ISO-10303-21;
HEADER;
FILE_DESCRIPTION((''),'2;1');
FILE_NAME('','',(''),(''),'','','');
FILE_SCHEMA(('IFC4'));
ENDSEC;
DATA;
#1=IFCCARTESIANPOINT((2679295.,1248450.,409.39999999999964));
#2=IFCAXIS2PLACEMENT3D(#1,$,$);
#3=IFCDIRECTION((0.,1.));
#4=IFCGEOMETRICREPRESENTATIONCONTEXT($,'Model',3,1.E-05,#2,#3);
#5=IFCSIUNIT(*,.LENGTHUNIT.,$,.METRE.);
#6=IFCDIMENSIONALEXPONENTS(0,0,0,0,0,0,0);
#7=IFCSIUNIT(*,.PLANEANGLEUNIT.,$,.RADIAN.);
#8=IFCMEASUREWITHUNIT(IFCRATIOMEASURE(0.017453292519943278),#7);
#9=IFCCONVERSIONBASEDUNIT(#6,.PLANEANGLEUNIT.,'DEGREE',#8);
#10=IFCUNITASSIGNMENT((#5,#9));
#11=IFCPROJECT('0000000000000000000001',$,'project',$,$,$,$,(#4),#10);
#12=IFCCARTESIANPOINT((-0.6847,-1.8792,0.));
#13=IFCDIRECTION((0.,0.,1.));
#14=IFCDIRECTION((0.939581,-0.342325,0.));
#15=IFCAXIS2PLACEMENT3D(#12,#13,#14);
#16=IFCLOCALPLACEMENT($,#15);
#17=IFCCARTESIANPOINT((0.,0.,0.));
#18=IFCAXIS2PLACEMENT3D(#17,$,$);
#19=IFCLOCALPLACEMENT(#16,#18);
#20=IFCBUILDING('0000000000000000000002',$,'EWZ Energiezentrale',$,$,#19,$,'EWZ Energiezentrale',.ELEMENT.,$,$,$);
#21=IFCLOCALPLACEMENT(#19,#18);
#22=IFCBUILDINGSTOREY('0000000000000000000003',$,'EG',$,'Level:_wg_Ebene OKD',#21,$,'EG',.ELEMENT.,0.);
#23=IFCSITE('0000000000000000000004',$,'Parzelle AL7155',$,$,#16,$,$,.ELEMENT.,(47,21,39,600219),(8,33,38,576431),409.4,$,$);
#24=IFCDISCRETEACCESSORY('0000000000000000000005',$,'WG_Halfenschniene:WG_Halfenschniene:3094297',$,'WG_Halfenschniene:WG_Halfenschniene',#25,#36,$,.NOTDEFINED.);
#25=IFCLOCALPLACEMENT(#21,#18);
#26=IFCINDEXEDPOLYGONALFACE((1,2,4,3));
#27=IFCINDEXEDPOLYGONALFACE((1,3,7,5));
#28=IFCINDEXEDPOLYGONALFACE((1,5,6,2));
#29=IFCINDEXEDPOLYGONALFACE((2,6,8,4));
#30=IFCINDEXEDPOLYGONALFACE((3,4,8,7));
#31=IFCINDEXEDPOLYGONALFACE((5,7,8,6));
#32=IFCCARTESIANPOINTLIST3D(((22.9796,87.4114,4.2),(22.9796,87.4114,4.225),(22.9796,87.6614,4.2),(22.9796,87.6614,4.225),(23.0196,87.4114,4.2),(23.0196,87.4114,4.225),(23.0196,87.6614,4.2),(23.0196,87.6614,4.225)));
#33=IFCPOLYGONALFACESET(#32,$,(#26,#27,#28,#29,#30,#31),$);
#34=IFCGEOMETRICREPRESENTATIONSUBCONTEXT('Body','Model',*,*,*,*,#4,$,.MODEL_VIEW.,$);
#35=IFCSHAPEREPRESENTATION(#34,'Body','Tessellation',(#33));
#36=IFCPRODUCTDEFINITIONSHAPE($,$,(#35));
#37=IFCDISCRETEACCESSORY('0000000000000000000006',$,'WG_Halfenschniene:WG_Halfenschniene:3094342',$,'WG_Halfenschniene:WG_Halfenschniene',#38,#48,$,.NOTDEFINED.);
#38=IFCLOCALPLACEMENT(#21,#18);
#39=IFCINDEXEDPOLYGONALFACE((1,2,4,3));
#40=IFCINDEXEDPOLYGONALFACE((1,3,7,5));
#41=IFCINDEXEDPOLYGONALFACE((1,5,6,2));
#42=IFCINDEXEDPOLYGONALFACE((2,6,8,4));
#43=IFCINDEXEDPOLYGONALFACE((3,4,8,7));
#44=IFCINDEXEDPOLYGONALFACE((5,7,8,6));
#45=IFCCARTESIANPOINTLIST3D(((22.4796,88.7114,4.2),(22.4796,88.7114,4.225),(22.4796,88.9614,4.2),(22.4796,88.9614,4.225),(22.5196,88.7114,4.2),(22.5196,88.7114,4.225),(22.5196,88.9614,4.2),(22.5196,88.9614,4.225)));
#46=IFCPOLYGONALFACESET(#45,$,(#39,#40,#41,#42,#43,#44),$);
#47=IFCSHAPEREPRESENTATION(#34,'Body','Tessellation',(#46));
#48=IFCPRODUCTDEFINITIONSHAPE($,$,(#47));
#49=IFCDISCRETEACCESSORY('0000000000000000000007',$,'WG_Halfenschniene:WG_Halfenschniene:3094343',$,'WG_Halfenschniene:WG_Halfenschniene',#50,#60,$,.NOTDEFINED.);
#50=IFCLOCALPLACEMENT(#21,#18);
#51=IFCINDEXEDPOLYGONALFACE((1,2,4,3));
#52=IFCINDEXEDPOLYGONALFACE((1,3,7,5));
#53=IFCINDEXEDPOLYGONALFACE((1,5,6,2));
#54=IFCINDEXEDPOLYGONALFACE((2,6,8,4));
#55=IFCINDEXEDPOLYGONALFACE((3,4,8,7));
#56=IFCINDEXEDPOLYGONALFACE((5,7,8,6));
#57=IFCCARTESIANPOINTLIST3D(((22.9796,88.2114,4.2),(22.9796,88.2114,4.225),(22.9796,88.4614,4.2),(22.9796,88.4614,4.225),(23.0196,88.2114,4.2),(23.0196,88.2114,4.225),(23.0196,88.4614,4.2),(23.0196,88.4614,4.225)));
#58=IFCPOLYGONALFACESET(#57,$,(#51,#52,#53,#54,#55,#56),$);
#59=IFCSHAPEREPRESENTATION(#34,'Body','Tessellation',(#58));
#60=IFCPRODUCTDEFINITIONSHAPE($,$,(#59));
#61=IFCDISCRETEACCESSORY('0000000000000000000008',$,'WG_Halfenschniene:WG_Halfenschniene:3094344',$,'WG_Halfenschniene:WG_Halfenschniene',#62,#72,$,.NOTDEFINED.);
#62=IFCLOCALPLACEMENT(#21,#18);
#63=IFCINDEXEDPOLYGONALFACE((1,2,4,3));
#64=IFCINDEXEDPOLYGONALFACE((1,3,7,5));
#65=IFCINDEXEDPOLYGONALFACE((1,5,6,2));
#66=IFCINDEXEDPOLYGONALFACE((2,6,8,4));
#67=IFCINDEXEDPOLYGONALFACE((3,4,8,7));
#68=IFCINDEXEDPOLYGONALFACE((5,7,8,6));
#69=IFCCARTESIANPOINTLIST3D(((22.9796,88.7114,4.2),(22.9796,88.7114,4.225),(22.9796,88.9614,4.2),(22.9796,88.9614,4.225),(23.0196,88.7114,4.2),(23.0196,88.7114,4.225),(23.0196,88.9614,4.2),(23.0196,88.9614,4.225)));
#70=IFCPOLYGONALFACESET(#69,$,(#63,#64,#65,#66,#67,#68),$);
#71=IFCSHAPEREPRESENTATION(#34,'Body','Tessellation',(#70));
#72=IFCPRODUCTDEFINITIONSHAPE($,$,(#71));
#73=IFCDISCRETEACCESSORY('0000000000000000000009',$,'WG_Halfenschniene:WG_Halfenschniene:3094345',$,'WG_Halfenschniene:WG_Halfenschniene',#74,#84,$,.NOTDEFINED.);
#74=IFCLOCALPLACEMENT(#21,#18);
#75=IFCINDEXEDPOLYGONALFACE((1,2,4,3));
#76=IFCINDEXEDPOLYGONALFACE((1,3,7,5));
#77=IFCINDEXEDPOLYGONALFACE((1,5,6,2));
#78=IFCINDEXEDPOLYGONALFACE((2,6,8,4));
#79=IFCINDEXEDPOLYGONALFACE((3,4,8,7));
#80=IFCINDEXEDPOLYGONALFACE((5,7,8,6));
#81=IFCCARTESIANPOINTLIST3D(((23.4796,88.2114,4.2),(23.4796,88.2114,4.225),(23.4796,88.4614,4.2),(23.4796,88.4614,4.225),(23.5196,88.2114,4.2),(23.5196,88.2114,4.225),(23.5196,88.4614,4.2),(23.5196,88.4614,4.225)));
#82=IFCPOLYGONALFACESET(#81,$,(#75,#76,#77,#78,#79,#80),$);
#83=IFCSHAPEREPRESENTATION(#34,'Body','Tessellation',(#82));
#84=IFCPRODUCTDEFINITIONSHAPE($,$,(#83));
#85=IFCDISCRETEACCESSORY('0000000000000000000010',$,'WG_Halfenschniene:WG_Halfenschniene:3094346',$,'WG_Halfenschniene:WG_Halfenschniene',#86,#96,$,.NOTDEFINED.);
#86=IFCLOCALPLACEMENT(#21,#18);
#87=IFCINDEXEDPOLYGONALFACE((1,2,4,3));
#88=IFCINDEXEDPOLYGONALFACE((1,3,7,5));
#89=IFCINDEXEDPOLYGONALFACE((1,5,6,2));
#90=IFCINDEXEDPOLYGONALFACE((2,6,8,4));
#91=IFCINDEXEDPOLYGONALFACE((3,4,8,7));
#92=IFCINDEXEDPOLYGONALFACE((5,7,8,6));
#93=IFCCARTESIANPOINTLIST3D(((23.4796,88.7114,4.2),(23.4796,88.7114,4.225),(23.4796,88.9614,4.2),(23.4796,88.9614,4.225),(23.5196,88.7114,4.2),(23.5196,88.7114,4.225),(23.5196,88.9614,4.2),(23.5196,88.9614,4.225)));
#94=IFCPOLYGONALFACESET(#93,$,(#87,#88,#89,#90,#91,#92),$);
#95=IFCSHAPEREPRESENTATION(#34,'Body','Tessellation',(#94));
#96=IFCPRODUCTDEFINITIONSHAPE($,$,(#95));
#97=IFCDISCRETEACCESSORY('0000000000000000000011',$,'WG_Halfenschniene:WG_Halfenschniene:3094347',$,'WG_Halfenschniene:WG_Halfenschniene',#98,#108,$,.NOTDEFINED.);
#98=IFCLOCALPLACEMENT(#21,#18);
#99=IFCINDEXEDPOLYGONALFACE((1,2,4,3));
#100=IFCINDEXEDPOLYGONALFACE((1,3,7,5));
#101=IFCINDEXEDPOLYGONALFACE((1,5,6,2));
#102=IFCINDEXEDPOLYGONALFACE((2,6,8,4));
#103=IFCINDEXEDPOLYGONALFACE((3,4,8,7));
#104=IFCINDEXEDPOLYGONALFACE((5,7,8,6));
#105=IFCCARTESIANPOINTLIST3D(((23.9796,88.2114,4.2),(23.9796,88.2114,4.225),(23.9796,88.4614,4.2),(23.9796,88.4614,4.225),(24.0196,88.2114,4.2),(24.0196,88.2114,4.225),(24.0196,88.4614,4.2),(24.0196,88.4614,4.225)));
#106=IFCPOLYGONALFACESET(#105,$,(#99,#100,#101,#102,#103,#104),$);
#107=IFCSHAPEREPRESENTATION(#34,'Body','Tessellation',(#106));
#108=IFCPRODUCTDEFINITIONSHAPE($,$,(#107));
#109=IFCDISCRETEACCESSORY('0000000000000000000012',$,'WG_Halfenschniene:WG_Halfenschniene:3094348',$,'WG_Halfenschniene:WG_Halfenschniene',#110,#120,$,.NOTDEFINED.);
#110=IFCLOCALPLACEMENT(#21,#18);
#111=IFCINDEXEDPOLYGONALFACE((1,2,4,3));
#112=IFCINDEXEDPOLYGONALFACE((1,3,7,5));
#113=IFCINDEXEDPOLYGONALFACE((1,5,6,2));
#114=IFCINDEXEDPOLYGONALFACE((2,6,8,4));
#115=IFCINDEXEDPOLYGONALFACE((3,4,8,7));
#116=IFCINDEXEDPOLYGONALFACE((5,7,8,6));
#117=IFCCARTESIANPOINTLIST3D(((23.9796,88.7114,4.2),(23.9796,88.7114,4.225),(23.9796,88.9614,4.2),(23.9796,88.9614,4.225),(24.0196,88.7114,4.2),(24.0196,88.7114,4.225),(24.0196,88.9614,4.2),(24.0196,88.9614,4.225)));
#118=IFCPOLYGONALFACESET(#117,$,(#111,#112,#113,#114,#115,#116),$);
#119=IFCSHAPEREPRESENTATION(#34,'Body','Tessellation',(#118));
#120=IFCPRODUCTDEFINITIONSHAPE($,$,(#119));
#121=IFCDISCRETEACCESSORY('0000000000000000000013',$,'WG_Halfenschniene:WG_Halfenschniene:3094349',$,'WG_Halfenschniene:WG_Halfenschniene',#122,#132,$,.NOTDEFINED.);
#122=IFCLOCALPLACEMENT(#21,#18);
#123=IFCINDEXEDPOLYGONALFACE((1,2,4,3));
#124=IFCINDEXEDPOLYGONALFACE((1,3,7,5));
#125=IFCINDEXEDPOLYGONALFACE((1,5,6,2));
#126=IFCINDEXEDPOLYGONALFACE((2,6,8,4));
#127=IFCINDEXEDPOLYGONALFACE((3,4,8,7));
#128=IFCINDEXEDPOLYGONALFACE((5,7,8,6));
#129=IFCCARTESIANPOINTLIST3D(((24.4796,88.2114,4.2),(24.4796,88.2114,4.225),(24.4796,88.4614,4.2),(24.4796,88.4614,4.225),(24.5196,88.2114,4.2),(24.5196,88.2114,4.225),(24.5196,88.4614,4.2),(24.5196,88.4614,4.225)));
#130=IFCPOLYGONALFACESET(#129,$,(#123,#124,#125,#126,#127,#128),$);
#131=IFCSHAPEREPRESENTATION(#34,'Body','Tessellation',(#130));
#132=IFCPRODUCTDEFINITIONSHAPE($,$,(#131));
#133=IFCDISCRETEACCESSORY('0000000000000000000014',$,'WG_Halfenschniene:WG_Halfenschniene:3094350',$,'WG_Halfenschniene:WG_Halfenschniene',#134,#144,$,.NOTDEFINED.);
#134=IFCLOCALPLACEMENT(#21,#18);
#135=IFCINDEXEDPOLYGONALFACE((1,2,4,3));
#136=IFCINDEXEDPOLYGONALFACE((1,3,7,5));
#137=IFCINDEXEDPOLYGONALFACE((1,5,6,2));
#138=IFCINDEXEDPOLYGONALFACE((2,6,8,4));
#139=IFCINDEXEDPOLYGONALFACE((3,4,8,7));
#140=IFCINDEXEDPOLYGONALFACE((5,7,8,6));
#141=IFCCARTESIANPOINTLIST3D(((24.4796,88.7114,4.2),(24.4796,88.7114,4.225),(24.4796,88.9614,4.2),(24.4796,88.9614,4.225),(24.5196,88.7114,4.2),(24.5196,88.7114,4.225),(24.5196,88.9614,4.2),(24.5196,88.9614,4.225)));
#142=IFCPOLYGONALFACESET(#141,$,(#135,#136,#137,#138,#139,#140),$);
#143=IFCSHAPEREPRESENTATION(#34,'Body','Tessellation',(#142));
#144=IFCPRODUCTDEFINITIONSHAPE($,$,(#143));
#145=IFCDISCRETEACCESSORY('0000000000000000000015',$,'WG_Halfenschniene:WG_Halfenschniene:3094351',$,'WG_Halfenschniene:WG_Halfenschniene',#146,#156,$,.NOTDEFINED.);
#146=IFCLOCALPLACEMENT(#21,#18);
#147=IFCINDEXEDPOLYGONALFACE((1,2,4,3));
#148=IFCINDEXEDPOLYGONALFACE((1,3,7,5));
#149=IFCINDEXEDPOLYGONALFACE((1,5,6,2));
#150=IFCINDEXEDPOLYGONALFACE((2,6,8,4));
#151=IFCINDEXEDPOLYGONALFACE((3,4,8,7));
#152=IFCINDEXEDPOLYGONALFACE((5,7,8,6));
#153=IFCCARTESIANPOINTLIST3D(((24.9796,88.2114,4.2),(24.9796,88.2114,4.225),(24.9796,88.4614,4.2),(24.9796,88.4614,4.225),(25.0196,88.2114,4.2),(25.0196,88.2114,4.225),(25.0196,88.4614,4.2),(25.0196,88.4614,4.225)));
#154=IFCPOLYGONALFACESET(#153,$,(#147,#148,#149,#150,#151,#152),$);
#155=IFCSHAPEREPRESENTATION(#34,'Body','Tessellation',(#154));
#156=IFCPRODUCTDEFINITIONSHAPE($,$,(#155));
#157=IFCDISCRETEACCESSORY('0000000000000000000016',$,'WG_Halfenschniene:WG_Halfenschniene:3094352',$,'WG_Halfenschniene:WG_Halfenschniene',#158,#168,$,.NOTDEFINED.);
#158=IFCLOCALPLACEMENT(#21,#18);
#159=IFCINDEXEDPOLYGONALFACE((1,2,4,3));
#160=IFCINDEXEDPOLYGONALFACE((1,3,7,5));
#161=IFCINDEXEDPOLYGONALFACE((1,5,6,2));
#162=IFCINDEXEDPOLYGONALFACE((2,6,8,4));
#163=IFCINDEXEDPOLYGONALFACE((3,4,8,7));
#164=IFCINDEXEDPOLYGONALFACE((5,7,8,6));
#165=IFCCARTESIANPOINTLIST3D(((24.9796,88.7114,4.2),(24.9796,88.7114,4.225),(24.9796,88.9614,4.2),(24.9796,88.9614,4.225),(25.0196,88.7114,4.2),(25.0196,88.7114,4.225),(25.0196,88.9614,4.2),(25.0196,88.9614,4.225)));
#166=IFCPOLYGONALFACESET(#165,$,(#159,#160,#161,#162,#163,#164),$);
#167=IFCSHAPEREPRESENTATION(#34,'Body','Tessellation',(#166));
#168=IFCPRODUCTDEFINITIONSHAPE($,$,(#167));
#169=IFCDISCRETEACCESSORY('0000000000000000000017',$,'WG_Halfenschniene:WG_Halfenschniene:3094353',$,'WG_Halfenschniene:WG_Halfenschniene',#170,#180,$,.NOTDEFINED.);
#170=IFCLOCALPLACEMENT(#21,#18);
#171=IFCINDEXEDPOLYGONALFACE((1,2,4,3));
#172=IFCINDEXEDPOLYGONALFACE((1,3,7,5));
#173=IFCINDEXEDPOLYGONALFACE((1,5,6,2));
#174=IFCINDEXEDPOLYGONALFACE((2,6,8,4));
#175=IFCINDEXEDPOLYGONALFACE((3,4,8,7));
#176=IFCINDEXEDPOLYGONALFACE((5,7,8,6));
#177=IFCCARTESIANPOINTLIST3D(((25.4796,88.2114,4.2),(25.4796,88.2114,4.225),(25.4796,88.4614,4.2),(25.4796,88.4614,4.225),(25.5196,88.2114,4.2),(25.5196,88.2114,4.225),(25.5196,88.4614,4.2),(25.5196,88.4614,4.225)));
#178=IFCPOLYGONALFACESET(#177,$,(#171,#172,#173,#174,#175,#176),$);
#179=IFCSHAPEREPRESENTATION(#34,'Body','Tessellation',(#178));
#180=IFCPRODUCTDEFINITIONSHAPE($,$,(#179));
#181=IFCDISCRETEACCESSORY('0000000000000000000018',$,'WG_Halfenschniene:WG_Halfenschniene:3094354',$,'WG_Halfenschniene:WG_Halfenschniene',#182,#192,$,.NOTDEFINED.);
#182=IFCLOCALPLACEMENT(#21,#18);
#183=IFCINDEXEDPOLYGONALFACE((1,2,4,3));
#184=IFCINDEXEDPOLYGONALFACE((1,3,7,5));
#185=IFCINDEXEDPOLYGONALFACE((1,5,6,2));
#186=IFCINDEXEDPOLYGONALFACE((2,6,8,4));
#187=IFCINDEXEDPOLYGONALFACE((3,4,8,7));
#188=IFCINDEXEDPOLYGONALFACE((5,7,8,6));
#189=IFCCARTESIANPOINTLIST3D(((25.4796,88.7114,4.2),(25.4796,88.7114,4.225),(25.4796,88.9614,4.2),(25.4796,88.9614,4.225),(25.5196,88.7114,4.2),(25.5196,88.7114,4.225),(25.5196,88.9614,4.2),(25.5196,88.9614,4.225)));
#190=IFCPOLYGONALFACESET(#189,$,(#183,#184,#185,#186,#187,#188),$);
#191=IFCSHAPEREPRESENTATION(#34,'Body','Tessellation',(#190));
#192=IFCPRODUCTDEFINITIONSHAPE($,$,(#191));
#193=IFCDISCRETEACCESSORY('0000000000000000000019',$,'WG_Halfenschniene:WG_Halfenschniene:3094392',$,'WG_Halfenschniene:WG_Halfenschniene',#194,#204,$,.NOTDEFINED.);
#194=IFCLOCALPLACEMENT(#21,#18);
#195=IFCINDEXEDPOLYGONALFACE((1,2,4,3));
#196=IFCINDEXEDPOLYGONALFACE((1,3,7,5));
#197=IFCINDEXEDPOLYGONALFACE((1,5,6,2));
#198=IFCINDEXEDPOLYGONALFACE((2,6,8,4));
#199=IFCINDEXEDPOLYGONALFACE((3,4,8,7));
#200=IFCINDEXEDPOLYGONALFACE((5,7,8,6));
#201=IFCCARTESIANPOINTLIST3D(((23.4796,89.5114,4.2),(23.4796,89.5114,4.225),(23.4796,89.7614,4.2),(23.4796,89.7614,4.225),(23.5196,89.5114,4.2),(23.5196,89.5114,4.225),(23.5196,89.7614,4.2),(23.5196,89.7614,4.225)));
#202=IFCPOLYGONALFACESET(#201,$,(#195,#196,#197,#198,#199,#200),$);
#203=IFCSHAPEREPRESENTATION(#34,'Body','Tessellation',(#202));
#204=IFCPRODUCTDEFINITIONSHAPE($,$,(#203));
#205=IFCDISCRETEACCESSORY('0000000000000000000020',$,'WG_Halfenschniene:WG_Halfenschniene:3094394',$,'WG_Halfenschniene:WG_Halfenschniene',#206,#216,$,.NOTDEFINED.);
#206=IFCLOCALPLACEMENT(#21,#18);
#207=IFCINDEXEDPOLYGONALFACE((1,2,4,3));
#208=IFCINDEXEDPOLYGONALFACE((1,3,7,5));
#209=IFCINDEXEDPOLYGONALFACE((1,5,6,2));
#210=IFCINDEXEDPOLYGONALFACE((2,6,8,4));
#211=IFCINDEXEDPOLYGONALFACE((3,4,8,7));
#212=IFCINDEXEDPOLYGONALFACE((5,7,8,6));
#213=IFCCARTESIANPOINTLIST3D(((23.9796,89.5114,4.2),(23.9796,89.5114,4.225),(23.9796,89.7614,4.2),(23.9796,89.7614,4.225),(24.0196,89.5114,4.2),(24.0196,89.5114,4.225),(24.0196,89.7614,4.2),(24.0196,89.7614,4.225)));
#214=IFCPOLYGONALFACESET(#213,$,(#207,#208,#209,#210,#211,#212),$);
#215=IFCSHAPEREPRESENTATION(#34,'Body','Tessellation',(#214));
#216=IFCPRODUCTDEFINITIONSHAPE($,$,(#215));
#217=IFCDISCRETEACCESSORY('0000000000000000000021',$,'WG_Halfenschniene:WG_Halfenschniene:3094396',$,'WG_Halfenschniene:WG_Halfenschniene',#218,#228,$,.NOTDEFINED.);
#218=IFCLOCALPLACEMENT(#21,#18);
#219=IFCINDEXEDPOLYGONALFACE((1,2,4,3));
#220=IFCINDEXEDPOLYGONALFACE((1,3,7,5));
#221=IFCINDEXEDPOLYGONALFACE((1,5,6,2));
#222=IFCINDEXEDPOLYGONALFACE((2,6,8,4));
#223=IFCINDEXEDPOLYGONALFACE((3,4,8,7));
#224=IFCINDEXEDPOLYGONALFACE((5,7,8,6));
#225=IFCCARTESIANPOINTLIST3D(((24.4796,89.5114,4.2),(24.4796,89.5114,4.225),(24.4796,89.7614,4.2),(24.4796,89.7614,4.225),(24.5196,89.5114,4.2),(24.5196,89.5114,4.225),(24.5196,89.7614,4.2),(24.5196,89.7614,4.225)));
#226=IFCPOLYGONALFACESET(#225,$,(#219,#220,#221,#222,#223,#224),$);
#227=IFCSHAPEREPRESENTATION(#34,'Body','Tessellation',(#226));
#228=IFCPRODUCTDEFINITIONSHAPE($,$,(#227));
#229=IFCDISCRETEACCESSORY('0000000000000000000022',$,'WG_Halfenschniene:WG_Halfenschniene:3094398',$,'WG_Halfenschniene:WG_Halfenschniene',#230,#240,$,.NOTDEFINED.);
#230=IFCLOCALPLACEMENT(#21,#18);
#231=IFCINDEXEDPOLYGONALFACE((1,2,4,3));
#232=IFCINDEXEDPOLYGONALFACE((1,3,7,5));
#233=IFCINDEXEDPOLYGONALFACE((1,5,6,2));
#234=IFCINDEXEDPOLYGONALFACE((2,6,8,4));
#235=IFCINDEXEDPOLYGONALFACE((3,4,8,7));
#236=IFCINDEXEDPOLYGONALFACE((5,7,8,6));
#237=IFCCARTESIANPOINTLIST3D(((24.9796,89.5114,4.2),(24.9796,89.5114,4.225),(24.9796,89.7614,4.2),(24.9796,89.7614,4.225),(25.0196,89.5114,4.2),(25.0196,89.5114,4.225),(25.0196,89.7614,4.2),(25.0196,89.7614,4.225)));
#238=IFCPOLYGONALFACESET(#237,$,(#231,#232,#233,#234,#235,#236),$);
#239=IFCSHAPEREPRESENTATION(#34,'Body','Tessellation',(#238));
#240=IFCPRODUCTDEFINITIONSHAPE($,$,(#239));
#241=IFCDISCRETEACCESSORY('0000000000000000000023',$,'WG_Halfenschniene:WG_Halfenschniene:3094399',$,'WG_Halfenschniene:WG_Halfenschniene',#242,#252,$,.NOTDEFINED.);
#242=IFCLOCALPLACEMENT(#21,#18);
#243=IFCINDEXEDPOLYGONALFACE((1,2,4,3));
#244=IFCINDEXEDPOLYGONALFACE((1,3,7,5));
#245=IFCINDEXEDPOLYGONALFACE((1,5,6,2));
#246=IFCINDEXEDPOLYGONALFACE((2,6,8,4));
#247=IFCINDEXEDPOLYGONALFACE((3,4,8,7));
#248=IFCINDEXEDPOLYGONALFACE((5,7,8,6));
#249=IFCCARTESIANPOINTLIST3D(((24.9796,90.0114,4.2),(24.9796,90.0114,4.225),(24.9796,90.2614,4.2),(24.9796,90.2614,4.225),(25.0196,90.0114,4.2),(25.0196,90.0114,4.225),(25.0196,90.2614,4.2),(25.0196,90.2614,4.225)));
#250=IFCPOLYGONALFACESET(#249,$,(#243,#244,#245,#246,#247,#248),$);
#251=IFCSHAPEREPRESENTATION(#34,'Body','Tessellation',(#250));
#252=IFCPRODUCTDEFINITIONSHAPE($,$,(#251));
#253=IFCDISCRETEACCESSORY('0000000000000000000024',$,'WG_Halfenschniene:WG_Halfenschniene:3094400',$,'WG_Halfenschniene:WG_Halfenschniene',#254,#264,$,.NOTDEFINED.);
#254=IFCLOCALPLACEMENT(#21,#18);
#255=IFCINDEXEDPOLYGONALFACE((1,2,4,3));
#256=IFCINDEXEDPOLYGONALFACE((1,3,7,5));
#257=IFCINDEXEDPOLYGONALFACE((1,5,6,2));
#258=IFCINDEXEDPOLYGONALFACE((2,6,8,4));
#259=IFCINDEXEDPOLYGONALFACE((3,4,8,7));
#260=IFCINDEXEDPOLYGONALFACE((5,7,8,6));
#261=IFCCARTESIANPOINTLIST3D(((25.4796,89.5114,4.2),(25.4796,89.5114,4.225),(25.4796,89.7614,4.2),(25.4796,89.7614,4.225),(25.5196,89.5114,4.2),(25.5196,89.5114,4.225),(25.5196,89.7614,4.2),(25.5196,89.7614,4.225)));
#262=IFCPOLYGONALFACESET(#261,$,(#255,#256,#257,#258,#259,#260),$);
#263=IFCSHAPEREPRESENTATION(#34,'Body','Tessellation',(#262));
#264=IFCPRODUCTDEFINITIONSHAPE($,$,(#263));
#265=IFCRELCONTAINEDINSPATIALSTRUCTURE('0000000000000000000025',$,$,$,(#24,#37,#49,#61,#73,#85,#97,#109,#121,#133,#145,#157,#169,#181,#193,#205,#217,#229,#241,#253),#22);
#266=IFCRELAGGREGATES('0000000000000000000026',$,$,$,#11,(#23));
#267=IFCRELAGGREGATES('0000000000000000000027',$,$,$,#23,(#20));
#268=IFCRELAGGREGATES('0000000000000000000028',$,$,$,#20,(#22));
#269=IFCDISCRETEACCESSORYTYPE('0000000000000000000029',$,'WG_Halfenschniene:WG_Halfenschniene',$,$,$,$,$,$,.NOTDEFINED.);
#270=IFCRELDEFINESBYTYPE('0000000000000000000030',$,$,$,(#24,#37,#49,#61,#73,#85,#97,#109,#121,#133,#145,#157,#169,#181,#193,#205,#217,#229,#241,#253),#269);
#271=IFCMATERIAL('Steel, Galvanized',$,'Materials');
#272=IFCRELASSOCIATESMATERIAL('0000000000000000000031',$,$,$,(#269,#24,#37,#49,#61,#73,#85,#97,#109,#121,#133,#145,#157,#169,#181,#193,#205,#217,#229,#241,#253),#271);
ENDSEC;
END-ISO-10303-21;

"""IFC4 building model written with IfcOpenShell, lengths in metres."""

from ifc_helpers import new_model, entity, si_unit, converted_unit, direction, frame, origin, place, context, subcontext, project, spatial, indexed_curve, outline, extrude, source, transform, mapped, material, type_object, element, save


model = new_model("IFC4")

# Units and contexts
model_context = context("Model", 3, precision=1e-05, world=frame((2679295.0, 1248450.0, 409.39999999999964)), true_north=direction((0.0, 1.0)))
body_context = subcontext(model_context, "Body", "Model", "MODEL_VIEW")
ifc_project = project(units=[si_unit("LENGTHUNIT", "METRE"), converted_unit("PLANEANGLEUNIT", "DEGREE", entity("IfcRatioMeasure", 0.017453292519943278), si_unit("PLANEANGLEUNIT", "RADIAN"), dimensions=[0, 0, 0, 0, 0, 0, 0])], contexts=[model_context])

# Site, building, storey
site_placement = place(None, frame((-0.6847, -1.8792, 0.0), z_axis=(0.0, 0.0, 1.0), x_axis=(0.939581, -0.342325, 0.0)))
site = spatial("IfcSite", under=ifc_project, at=site_placement, Name="Parzelle AL7155", CompositionType="ELEMENT", RefLatitude=(47, 21, 39, 600219), RefLongitude=(8, 33, 38, 576431), RefElevation=409.4)
building_placement = place(site_placement, origin())
building = spatial("IfcBuilding", under=site, at=building_placement, Name="EWZ Energiezentrale", LongName="EWZ Energiezentrale", CompositionType="ELEMENT")
storey_placement = place(building_placement, origin())
storey = spatial("IfcBuildingStorey", under=building, at=storey_placement, Name="EG", ObjectType="Level:_wg_Ebene OKD", LongName="EG", CompositionType="ELEMENT", Elevation=0.0)

# Discrete accessories
ifc_material = material(Name="Steel, Galvanized", Category="Materials")
discrete_accessory_type = type_object("IfcDiscreteAccessoryType", Name="WG_Halfenschniene:WG_Halfenschniene", PredefinedType="NOTDEFINED", material=ifc_material)
shared_shape = source(origin(), body_context, "Body", "SweptSolid", [
    extrude(outline(indexed_curve([(-0.125, -0.02), (0.125, -0.02), (0.125, 0.02), (-0.125, 0.02), (-0.125, -0.02)], self_intersect=False)), frame((0.125, 0.0, -0.0125)), (0.0, 0.0, 1.0), 0.025),
])
for number, where, z_axis, x_axis, name in (
    (1, (22.9996, 87.4114, 4.2125), (0.0, 0.0, -1.0), (0.0, 1.0, 0.0), "WG_Halfenschniene:WG_Halfenschniene:3094297"),
    (2, (22.4996, 88.7114, 4.2125), (0.0, 0.0, -1.0), (0.0, 1.0, 0.0), "WG_Halfenschniene:WG_Halfenschniene:3094342"),
    (3, (22.9996, 88.2114, 4.2125), (0.0, 0.0, -1.0), (0.0, 1.0, 0.0), "WG_Halfenschniene:WG_Halfenschniene:3094343"),
    (4, (22.9996, 88.7114, 4.2125), (0.0, 0.0, -1.0), (0.0, 1.0, 0.0), "WG_Halfenschniene:WG_Halfenschniene:3094344"),
    (5, (23.4996, 88.2114, 4.2125), (0.0, 0.0, -1.0), (0.0, 1.0, 0.0), "WG_Halfenschniene:WG_Halfenschniene:3094345"),
    (6, (23.4996, 88.7114, 4.2125), (0.0, 0.0, -1.0), (0.0, 1.0, 0.0), "WG_Halfenschniene:WG_Halfenschniene:3094346"),
    (7, (23.9996, 88.2114, 4.2125), (0.0, 0.0, -1.0), (0.0, 1.0, 0.0), "WG_Halfenschniene:WG_Halfenschniene:3094347"),
    (8, (23.9996, 88.7114, 4.2125), (0.0, 0.0, -1.0), (0.0, 1.0, 0.0), "WG_Halfenschniene:WG_Halfenschniene:3094348"),
    (9, (24.4996, 88.2114, 4.2125), (0.0, 0.0, -1.0), (0.0, 1.0, 0.0), "WG_Halfenschniene:WG_Halfenschniene:3094349"),
    (10, (24.4996, 88.7114, 4.2125), (0.0, 0.0, -1.0), (0.0, 1.0, 0.0), "WG_Halfenschniene:WG_Halfenschniene:3094350"),
    (11, (24.9996, 88.2114, 4.2125), (0.0, 0.0, -1.0), (0.0, 1.0, 0.0), "WG_Halfenschniene:WG_Halfenschniene:3094351"),
    (12, (24.9996, 88.7114, 4.2125), (0.0, 0.0, -1.0), (0.0, 1.0, 0.0), "WG_Halfenschniene:WG_Halfenschniene:3094352"),
    (13, (25.4996, 88.2114, 4.2125), (0.0, 0.0, -1.0), (0.0, 1.0, 0.0), "WG_Halfenschniene:WG_Halfenschniene:3094353"),
    (14, (25.4996, 88.7114, 4.2125), (0.0, 0.0, -1.0), (0.0, 1.0, 0.0), "WG_Halfenschniene:WG_Halfenschniene:3094354"),
    (15, (23.4996, 89.5114, 4.2125), (0.0, 0.0, -1.0), (0.0, 1.0, 0.0), "WG_Halfenschniene:WG_Halfenschniene:3094392"),
    (16, (23.9996, 89.5114, 4.2125), (0.0, 0.0, -1.0), (0.0, 1.0, 0.0), "WG_Halfenschniene:WG_Halfenschniene:3094394"),
    (17, (24.4996, 89.5114, 4.2125), (0.0, 0.0, -1.0), (0.0, 1.0, 0.0), "WG_Halfenschniene:WG_Halfenschniene:3094396"),
    (18, (24.9996, 89.5114, 4.2125), (0.0, 0.0, -1.0), (0.0, 1.0, 0.0), "WG_Halfenschniene:WG_Halfenschniene:3094398"),
    (19, (24.9996, 90.0114, 4.2125), (0.0, 0.0, -1.0), (0.0, 1.0, 0.0), "WG_Halfenschniene:WG_Halfenschniene:3094399"),
    (20, (25.4996, 89.5114, 4.2125), (0.0, 0.0, -1.0), (0.0, 1.0, 0.0), "WG_Halfenschniene:WG_Halfenschniene:3094400"),
):
    element("IfcDiscreteAccessory", number, at=place(storey_placement, frame(where, z_axis=z_axis, x_axis=x_axis)), inside=storey, type_object=discrete_accessory_type, material=ifc_material, Name=name, ObjectType="WG_Halfenschniene:WG_Halfenschniene", PredefinedType="NOTDEFINED", context=body_context, shape_type="MappedRepresentation", body=[
        mapped(shared_shape, transform((0.0, 0.0, 0.0), scale=1.0)),
    ])

save(model, "model.ifc")
